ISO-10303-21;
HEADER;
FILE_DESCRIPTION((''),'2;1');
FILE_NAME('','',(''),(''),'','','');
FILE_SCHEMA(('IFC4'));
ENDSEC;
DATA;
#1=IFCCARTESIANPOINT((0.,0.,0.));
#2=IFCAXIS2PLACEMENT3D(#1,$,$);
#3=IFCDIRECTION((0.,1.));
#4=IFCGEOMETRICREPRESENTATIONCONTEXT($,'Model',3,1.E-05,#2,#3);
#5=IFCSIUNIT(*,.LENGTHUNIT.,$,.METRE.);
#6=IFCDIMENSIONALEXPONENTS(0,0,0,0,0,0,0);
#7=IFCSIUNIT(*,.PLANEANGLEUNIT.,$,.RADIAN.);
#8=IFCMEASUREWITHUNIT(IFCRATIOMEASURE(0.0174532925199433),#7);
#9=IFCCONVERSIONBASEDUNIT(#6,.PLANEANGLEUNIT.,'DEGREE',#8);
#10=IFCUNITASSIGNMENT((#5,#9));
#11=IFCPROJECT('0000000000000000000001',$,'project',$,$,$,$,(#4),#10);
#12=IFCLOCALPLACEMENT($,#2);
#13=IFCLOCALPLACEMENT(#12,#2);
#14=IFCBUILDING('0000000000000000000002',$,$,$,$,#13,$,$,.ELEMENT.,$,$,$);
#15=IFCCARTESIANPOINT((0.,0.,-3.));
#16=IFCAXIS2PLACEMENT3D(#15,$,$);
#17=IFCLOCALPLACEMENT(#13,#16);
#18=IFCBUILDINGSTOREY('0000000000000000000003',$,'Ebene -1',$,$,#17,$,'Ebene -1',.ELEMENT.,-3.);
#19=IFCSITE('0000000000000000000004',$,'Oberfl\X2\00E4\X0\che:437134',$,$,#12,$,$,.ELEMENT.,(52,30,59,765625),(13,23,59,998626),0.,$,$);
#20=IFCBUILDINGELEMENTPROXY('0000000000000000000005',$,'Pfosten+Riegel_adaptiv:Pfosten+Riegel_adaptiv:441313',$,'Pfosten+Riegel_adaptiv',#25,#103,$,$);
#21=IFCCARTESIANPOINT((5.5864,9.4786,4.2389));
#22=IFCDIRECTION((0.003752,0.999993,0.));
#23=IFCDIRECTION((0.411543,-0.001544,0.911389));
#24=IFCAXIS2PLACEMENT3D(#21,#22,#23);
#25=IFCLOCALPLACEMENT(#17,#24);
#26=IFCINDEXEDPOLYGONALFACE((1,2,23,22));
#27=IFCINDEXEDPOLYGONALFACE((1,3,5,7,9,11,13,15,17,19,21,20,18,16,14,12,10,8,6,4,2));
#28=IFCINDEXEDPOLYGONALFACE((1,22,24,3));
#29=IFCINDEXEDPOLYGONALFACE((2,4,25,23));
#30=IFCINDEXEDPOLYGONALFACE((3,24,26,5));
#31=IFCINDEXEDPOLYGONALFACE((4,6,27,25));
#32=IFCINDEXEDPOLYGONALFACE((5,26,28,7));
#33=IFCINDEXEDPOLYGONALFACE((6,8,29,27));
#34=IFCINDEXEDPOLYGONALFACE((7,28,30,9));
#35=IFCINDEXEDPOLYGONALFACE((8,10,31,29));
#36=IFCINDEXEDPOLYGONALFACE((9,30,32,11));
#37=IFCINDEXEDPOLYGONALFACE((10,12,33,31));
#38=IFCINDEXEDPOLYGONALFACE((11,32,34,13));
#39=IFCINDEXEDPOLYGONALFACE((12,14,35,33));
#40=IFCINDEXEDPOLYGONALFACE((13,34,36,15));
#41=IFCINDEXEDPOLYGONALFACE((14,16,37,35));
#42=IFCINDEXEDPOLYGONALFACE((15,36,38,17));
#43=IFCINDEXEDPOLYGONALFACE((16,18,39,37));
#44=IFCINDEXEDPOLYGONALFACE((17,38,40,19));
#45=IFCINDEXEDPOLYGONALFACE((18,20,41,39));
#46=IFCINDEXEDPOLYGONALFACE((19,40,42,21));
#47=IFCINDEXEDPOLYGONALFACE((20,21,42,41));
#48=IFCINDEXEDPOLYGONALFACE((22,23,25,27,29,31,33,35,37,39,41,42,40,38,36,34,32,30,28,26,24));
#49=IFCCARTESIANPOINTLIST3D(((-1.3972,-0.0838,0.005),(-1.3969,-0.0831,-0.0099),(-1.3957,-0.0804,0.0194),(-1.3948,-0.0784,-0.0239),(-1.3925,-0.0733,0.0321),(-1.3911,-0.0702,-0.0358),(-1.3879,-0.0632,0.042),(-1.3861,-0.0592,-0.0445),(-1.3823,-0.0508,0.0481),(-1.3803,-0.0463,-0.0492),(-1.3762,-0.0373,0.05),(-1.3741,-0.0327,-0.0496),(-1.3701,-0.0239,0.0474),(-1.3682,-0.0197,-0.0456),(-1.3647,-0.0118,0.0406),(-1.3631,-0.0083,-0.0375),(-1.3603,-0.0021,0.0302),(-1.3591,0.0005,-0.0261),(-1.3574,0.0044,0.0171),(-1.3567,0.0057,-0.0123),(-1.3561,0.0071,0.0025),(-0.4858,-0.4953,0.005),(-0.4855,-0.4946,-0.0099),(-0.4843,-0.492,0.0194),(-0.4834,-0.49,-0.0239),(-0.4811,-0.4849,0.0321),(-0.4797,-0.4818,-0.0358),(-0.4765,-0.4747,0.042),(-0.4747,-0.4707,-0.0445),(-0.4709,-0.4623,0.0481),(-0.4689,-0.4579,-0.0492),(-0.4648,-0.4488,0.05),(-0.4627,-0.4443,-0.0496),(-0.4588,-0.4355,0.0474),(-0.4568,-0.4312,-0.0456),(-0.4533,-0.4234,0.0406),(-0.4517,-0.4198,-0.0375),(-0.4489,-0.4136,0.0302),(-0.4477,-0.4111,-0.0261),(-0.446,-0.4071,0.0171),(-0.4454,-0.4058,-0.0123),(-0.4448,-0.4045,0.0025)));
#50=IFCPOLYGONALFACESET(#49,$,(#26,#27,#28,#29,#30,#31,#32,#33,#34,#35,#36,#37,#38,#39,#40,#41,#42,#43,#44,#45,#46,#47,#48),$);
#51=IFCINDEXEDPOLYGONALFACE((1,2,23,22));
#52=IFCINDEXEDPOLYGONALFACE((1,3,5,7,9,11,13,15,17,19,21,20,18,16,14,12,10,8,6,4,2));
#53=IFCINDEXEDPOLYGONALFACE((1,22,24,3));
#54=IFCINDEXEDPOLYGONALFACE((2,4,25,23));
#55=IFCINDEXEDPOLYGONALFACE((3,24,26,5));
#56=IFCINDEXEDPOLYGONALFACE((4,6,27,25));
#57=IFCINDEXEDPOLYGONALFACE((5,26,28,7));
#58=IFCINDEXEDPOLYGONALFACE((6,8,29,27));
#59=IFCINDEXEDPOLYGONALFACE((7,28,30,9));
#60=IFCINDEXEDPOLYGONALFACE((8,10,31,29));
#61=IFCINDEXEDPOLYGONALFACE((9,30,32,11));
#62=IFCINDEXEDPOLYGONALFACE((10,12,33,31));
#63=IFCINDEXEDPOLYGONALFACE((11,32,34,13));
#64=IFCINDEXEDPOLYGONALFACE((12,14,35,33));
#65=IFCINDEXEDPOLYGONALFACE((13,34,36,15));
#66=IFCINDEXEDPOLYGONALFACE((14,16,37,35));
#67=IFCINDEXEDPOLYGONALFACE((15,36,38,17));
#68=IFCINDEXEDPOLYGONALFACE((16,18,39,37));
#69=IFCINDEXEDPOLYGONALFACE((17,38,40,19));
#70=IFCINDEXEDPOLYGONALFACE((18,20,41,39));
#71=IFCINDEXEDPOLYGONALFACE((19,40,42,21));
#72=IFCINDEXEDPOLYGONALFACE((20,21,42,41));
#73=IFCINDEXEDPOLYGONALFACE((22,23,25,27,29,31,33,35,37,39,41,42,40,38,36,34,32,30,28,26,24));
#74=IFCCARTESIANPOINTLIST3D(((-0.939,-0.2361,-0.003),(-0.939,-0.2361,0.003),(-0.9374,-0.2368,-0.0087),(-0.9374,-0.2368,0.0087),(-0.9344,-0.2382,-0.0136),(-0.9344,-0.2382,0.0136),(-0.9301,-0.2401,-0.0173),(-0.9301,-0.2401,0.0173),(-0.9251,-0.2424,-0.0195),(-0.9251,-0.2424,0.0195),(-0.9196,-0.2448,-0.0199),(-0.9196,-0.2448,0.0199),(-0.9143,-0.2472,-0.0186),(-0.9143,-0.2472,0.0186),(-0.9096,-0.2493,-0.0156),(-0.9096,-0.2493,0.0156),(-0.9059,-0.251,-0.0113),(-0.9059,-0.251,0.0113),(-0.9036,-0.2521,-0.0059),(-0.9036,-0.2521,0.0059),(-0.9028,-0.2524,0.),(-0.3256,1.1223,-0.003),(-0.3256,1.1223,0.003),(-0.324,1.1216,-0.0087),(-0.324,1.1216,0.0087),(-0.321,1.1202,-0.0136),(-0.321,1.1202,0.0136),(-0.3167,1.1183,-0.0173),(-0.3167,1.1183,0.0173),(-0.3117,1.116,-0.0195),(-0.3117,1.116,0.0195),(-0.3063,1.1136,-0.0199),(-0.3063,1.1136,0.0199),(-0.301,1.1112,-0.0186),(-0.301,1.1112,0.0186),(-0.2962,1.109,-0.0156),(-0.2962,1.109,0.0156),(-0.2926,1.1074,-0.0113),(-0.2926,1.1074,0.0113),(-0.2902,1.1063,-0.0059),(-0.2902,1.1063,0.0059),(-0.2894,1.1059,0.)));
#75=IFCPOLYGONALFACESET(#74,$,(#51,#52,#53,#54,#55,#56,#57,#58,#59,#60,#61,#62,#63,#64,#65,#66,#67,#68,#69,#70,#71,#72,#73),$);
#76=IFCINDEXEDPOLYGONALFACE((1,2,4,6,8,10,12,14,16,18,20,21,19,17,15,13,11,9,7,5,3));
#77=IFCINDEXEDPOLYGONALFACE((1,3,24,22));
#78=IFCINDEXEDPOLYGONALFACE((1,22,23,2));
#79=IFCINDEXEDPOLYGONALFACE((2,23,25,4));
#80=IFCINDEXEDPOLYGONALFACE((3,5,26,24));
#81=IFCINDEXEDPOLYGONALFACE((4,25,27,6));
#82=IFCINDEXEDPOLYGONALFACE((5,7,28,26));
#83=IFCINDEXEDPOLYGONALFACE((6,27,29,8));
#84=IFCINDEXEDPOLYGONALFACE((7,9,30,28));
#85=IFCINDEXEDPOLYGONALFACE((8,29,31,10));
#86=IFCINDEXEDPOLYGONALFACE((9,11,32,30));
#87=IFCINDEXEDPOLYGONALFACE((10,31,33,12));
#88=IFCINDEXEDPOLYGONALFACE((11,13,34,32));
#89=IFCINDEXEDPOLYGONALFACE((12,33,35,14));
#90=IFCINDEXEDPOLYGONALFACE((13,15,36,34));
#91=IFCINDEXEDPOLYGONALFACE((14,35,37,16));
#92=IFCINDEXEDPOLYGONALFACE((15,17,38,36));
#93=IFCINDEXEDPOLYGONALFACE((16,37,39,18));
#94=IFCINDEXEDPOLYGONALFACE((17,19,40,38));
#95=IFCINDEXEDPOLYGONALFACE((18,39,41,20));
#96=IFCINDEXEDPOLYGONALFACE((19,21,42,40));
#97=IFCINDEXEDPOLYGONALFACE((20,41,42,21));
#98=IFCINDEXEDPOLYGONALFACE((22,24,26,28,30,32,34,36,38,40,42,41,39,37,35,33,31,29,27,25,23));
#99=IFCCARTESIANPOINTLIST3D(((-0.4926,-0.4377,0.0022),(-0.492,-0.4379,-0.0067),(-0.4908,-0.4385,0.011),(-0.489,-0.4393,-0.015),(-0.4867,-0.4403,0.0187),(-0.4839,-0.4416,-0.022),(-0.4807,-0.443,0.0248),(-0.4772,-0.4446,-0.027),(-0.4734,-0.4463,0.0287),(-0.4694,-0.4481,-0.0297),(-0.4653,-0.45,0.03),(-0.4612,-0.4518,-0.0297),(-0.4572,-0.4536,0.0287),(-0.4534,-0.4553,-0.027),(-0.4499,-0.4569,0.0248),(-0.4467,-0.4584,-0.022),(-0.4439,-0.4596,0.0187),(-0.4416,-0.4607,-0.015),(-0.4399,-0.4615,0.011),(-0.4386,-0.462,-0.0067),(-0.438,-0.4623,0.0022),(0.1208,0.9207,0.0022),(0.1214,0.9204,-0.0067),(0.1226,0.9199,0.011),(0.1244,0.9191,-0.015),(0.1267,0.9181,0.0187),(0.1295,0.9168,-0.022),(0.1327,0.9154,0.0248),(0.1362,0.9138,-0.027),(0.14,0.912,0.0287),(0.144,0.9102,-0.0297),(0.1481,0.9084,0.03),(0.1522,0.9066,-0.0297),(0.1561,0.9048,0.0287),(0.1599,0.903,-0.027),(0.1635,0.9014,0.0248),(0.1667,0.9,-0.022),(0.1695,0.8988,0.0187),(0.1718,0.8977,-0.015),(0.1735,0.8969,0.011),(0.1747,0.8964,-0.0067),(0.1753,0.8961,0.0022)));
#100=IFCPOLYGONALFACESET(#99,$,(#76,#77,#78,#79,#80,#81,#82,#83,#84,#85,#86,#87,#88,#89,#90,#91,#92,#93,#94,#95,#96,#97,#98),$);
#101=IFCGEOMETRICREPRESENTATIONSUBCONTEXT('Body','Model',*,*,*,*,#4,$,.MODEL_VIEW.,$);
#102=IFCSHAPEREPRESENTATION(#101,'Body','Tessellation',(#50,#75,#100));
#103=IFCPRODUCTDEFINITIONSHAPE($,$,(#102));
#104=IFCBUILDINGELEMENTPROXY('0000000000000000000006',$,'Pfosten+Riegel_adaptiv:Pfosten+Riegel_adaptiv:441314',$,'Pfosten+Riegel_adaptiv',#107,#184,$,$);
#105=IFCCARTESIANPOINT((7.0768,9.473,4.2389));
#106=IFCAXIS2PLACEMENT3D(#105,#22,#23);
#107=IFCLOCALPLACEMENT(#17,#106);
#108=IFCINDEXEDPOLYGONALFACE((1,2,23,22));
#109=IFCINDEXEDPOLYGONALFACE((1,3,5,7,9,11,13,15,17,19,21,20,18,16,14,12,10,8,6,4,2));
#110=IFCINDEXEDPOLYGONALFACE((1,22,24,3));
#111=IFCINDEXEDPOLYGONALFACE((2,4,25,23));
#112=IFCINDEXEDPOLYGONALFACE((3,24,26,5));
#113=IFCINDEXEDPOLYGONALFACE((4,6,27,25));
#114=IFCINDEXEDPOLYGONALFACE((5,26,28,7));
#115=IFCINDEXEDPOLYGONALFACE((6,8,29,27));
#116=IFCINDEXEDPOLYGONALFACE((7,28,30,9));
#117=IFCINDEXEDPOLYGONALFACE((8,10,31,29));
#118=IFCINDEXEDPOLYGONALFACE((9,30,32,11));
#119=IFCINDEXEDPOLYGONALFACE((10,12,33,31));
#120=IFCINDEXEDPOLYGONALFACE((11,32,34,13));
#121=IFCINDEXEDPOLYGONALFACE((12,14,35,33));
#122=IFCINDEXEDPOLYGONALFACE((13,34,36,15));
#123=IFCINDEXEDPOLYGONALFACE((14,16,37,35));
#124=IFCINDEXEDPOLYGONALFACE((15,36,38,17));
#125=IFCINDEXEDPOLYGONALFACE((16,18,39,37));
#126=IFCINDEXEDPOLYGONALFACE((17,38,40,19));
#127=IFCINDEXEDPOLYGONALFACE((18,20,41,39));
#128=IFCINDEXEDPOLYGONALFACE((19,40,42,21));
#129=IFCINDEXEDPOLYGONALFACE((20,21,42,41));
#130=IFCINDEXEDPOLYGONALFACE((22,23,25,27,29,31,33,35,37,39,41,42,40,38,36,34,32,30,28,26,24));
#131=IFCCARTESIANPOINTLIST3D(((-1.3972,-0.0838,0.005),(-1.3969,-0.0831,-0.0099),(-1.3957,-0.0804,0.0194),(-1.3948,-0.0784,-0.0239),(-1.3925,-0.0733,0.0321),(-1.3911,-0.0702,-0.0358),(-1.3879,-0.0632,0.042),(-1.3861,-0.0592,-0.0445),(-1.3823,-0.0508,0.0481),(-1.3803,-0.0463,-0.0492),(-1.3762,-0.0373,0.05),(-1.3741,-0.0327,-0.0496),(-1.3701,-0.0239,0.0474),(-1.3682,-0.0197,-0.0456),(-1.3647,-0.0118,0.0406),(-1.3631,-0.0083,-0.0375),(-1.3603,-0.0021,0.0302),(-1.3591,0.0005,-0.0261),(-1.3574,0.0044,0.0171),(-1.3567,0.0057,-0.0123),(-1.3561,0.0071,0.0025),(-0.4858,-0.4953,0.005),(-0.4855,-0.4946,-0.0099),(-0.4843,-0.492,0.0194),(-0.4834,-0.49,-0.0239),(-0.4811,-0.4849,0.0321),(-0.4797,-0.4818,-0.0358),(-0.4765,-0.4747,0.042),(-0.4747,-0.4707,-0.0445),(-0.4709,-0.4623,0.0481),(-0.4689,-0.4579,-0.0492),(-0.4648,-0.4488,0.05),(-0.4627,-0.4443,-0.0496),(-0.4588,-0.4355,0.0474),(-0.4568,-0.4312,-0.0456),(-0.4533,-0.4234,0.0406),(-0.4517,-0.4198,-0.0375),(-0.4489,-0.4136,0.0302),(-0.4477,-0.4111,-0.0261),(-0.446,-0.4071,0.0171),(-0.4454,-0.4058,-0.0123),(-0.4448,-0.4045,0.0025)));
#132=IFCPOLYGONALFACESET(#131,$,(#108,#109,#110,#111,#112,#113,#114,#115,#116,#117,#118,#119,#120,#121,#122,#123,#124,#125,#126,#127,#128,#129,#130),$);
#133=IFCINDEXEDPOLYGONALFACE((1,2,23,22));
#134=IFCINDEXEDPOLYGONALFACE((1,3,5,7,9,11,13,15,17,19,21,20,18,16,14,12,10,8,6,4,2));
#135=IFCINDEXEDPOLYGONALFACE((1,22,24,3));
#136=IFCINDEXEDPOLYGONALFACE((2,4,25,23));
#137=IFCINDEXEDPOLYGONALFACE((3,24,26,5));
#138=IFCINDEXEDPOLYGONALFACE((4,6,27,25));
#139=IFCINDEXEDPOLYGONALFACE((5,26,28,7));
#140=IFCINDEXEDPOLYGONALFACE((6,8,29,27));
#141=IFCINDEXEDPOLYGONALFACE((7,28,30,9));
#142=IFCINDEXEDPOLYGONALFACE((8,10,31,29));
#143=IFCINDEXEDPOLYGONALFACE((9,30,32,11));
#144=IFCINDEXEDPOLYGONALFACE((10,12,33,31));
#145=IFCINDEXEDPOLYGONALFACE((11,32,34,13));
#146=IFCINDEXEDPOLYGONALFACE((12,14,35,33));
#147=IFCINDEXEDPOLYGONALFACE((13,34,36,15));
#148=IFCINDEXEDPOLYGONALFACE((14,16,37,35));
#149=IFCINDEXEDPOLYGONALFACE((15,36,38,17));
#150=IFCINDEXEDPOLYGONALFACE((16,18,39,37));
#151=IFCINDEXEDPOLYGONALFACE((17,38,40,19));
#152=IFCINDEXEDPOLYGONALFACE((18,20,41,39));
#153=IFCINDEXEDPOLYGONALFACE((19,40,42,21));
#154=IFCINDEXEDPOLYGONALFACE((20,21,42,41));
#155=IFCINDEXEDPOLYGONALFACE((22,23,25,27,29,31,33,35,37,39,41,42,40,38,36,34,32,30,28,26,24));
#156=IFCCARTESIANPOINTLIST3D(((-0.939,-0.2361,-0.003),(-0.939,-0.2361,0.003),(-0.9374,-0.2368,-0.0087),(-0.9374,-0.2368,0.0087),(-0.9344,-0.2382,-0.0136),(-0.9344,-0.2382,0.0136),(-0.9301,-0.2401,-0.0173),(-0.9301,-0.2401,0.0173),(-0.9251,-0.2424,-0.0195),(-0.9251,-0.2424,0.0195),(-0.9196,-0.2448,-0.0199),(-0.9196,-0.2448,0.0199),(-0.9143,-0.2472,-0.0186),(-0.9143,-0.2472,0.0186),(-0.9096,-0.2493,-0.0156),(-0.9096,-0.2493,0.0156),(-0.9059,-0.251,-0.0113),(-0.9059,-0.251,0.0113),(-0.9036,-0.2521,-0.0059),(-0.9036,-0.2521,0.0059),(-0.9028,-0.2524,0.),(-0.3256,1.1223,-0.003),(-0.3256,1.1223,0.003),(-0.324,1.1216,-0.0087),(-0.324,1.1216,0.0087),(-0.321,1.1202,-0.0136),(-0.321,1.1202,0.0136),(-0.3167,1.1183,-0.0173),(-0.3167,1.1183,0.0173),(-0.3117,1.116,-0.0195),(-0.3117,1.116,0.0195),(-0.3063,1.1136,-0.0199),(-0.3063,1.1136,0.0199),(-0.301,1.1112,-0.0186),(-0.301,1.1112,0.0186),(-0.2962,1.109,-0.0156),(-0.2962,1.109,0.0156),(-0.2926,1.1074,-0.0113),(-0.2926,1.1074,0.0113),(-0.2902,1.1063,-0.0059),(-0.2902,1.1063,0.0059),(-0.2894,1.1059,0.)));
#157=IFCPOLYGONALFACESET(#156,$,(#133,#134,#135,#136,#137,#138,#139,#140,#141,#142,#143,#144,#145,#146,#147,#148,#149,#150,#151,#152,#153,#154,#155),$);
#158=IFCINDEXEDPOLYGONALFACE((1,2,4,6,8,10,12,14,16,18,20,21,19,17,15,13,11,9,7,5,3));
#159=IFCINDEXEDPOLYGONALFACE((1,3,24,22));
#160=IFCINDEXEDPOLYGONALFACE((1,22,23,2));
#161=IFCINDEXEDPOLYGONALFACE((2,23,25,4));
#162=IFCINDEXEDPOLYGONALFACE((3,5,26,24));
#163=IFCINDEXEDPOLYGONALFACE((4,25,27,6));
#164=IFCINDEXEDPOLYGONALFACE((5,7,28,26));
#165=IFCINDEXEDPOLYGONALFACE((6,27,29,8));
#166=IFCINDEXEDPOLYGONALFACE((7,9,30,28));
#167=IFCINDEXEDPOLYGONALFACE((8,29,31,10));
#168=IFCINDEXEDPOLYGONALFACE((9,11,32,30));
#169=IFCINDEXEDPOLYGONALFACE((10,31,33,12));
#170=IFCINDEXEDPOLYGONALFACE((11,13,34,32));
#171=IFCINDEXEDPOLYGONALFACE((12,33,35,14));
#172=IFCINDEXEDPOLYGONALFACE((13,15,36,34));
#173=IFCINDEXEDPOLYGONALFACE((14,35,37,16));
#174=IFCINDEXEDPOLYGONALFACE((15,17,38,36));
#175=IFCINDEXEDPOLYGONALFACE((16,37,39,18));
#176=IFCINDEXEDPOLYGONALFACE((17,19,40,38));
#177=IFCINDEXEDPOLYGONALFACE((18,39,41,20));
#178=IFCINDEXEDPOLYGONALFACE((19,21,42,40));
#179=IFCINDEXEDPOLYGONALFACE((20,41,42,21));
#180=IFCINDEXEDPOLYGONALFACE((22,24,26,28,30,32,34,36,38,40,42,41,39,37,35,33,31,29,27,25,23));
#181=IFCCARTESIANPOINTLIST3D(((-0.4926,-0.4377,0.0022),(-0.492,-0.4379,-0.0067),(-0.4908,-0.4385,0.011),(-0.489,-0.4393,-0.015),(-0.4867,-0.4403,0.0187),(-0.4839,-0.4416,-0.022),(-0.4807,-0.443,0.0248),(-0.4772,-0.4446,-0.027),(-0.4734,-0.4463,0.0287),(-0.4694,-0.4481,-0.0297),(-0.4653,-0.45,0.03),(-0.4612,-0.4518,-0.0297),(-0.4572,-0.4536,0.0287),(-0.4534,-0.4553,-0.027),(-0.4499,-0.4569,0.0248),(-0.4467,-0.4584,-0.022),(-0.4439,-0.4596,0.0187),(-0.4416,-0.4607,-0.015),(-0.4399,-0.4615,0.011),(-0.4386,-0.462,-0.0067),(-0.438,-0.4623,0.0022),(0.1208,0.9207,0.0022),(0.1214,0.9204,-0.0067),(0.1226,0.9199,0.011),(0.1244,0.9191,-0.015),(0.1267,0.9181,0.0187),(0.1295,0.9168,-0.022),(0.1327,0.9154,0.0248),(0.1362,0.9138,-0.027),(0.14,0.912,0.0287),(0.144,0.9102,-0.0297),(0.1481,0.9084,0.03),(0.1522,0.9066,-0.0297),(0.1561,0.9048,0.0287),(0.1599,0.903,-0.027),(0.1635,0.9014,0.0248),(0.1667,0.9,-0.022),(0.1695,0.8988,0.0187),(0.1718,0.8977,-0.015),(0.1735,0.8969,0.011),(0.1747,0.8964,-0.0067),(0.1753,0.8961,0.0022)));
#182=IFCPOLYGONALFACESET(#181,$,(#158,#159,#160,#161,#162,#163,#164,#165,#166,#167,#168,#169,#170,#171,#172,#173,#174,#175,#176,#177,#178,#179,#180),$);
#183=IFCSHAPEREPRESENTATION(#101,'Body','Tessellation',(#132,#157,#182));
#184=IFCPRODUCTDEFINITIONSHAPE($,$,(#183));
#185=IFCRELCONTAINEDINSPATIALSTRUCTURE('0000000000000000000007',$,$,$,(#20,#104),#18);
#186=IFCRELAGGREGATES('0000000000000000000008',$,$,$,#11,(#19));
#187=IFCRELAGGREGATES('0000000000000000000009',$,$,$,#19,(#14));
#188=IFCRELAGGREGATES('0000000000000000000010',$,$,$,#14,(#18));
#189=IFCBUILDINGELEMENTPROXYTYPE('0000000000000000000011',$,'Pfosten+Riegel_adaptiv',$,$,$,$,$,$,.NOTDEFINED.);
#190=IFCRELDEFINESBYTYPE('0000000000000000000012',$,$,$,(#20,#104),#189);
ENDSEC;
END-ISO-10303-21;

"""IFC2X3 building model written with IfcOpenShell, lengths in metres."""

from ifc_helpers import new_model, entity, si_unit, converted_unit, direction, frame, frame_2d, origin, place, context, subcontext, project, spatial, circle, extrude, source, transform, mapped, type_object, type_shapes, element, save


model = new_model("IFC2X3")

# Units and contexts
model_context = context("Model", 3, precision=1e-05, world=origin(), true_north=direction((0.0, 1.0)))
body_context = subcontext(model_context, "Body", "Model", "MODEL_VIEW")
ifc_project = project(units=[si_unit("LENGTHUNIT", "METRE"), converted_unit("PLANEANGLEUNIT", "DEGREE", entity("IfcRatioMeasure", 0.0174532925199433), si_unit("PLANEANGLEUNIT", "RADIAN"), dimensions=[0, 0, 0, 0, 0, 0, 0])], contexts=[model_context])

# Site, building, storey
site_placement = place(None, origin())
site = spatial("IfcSite", under=ifc_project, at=site_placement, Name="Oberfläche:437134", CompositionType="ELEMENT", RefLatitude=(52, 30, 59, 765625), RefLongitude=(13, 23, 59, 998626), RefElevation=0.0)
building_placement = place(site_placement, origin())
building = spatial("IfcBuilding", under=site, at=building_placement, CompositionType="ELEMENT")
storey_placement = place(building_placement, frame((0.0, 0.0, -3.0)))
storey = spatial("IfcBuildingStorey", under=building, at=storey_placement, Name="Ebene -1", LongName="Ebene -1", CompositionType="ELEMENT", Elevation=-3.0)

# Building element proxies
building_element_proxy_type_1 = type_object("IfcBuildingElementProxyType", Name="Pfosten+Riegel_adaptiv", PredefinedType="NOTDEFINED")
shared_shape_1 = source(origin(), body_context, "Body", "SweptSolid", [
    extrude(circle(Radius=0.05, at=frame_2d((0.0, 0.0), x_axis=(1.0, 0.0))), frame((-0.4653, -0.45, 0.0), z_axis=(-0.911389, 0.411546, 0.0), x_axis=(0.16937, 0.375078, -0.911389)), (0.0, 0.0, 1.0), 1.0),
    extrude(circle(Radius=0.02, at=frame_2d((0.0, 0.0), x_axis=(1.0, 0.0))), frame((-0.921, -0.2442, 0.0), z_axis=(0.411546, 0.911389, 0.0), x_axis=(0.911389, -0.411546, 0.0)), (0.0, 0.0, 1.0), 1.4904),
    extrude(circle(Radius=0.03, at=frame_2d((0.0, 0.0), x_axis=(1.0, 0.0))), frame((-0.4653, -0.45, 0.0), z_axis=(0.411546, 0.911389, 0.0), x_axis=(0.0, 0.0, 1.0)), (0.0, 0.0, 1.0), 1.4904),
])
type_shapes(building_element_proxy_type_1, [shared_shape_1])
for number, where, z_axis, x_axis, name in (
    (1, (5.5864, 9.4786, 4.2389), (0.003752, 0.999993, 0.0), (0.411543, -0.001544, 0.911389), "Pfosten+Riegel_adaptiv:Pfosten+Riegel_adaptiv:441313"),
    (2, (7.0768, 9.473, 4.2389), (0.003752, 0.999993, 0.0), (0.411543, -0.001544, 0.911389), "Pfosten+Riegel_adaptiv:Pfosten+Riegel_adaptiv:441314"),
):
    element("IfcBuildingElementProxy", number, at=place(storey_placement, frame(where, z_axis=z_axis, x_axis=x_axis)), inside=storey, type_object=building_element_proxy_type_1, Name=name, ObjectType="Pfosten+Riegel_adaptiv", context=body_context, shape_type="MappedRepresentation", body=[
        mapped(shared_shape_1, transform((0.0, 0.0, 0.0), scale=1.0)),
    ])

save(model, "model.ifc")
